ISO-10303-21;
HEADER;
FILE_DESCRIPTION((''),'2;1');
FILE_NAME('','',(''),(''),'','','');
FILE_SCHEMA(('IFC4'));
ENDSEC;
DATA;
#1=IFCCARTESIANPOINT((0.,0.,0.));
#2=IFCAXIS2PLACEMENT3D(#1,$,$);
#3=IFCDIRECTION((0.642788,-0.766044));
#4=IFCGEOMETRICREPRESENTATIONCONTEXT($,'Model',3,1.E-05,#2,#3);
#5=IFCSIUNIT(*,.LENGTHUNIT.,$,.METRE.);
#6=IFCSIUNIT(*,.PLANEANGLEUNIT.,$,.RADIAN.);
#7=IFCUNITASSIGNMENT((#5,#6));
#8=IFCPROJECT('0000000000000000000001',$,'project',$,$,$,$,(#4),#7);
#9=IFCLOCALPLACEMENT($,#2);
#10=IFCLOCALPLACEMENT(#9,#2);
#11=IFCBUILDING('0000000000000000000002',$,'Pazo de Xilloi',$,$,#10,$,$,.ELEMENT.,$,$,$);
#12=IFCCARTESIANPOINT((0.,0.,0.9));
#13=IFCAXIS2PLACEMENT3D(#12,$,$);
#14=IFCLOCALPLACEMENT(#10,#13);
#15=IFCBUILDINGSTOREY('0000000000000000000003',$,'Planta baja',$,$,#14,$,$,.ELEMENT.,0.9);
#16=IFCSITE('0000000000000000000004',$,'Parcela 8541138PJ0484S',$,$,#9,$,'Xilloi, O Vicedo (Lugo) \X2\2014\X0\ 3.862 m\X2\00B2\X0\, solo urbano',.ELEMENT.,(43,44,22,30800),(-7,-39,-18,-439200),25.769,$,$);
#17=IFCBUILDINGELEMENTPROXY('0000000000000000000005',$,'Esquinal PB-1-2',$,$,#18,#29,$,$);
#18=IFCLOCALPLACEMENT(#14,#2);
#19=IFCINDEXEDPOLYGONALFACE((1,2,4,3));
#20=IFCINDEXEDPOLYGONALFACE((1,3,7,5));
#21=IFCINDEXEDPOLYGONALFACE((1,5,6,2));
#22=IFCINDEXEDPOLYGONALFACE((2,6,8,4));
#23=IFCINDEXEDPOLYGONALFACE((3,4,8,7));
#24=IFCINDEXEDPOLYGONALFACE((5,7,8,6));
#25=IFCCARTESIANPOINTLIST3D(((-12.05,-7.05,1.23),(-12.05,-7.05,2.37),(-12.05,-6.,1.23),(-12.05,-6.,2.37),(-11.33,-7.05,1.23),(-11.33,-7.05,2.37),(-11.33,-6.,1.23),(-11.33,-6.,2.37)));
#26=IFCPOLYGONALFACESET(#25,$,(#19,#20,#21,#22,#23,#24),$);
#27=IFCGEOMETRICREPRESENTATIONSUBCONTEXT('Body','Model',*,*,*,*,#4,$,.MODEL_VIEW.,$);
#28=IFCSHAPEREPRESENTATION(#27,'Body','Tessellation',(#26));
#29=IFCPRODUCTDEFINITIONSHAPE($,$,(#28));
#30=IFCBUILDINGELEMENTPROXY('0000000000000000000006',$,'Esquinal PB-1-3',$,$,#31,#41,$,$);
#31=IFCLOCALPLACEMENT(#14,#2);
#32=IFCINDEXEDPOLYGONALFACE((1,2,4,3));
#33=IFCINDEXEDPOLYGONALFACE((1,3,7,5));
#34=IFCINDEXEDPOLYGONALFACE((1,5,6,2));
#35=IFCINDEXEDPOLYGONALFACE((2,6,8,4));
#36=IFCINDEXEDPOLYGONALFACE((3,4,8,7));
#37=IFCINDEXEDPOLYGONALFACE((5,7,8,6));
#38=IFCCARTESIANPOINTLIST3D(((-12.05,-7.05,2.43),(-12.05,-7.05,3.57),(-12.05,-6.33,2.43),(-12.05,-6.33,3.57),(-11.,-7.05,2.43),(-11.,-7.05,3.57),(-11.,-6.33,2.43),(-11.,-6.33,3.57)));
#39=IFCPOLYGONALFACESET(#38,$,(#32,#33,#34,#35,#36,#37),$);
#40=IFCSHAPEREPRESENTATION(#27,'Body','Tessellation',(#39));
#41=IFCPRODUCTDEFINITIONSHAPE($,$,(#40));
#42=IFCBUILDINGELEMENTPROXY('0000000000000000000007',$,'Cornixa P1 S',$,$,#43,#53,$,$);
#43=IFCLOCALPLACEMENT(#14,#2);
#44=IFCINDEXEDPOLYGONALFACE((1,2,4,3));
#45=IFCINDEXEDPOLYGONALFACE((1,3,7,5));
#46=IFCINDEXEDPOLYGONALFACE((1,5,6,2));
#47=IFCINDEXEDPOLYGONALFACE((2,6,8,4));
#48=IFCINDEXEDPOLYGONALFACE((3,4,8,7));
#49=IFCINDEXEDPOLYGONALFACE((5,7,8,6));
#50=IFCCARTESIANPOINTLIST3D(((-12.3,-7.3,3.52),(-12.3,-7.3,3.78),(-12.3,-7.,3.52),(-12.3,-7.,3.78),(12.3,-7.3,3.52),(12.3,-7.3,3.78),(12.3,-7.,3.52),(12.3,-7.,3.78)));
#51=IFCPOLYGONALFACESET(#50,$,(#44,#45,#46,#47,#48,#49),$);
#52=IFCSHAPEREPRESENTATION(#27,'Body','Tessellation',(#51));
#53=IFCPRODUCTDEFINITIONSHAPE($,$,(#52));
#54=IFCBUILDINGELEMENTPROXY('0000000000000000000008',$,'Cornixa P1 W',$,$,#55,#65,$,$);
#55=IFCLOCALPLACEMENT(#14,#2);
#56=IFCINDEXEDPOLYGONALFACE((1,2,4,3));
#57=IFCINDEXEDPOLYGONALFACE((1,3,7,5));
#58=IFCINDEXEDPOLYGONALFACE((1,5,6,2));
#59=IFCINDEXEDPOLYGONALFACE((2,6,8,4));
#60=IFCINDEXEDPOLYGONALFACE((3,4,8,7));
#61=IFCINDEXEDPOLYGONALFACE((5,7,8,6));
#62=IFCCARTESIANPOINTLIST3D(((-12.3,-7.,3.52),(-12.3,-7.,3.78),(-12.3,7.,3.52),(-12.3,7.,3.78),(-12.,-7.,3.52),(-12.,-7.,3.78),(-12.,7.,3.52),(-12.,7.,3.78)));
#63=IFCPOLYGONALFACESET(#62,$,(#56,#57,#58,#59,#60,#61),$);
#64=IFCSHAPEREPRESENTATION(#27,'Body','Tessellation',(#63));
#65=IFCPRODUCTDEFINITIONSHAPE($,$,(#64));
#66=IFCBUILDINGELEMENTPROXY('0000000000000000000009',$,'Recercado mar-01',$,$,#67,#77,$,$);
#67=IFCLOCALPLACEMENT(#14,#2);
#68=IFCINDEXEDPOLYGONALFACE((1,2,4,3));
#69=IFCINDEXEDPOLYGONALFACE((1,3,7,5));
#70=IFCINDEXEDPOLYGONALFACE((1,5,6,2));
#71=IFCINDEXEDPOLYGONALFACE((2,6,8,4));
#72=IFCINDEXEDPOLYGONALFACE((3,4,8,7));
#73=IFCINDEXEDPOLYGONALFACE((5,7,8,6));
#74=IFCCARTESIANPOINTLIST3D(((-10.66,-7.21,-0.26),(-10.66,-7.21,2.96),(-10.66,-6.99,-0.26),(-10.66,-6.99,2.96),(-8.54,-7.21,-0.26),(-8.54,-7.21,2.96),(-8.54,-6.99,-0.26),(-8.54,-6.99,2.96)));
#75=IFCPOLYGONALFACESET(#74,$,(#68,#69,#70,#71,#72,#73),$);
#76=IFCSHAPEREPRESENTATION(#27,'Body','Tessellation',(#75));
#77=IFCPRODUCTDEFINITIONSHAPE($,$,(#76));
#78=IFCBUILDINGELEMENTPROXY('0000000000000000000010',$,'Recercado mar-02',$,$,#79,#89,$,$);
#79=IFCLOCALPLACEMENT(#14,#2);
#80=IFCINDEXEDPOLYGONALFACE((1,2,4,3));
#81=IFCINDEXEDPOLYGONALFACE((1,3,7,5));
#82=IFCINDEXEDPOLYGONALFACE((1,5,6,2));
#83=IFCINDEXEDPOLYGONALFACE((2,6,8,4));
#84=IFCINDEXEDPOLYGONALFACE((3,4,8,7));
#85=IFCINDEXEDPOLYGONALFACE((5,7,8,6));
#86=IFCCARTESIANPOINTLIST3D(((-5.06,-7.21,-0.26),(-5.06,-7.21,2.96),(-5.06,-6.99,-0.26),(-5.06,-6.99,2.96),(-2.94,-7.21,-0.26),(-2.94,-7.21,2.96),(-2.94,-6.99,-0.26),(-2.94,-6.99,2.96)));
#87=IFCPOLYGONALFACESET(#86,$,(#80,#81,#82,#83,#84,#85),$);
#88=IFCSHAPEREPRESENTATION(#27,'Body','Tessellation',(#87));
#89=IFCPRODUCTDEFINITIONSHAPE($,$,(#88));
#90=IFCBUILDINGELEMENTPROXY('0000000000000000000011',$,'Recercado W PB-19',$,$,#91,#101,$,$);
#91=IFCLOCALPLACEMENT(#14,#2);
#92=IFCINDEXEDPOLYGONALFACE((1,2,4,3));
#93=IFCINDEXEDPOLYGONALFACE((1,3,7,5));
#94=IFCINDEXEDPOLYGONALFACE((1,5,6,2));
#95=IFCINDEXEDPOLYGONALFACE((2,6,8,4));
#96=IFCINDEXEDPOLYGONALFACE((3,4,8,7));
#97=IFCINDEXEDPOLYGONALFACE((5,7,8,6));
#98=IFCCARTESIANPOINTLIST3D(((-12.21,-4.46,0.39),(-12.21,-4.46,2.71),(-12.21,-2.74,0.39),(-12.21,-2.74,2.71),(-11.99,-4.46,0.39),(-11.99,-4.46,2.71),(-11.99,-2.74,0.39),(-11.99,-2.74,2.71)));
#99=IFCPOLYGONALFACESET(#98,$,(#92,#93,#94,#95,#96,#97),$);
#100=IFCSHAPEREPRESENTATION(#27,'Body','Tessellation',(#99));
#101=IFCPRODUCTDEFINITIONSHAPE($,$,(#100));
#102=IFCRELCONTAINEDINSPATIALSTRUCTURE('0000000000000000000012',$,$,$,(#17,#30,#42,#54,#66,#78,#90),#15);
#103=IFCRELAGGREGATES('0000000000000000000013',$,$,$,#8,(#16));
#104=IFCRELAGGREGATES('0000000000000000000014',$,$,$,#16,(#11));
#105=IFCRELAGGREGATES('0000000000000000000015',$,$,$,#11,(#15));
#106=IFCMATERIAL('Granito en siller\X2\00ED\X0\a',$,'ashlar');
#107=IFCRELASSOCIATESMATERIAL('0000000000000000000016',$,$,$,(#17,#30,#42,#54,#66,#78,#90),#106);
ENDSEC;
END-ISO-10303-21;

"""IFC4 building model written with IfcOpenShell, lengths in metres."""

from ifc_helpers import new_model, si_unit, direction, frame, origin, origin_2d, place, context, subcontext, project, spatial, rectangle, extrude, material, element, save


model = new_model("IFC4")

# Units and contexts
model_context = context("Model", 3, precision=1e-05, world=origin(), true_north=direction((0.642788, -0.766044)))
body_context = subcontext(model_context, "Body", "Model", "MODEL_VIEW")
ifc_project = project(units=[si_unit("LENGTHUNIT", "METRE"), si_unit("PLANEANGLEUNIT", "RADIAN")], contexts=[model_context])

# Site, building, storey
site_placement = place(None, origin())
site = spatial("IfcSite", under=ifc_project, at=site_placement, Name="Parcela 8541138PJ0484S", LongName="Xilloi, O Vicedo (Lugo) — 3.862 m², solo urbano", CompositionType="ELEMENT", RefLatitude=(43, 44, 22, 30800), RefLongitude=(-7, -39, -18, -439200), RefElevation=25.769)
building_placement = place(site_placement, origin())
building = spatial("IfcBuilding", under=site, at=building_placement, Name="Pazo de Xilloi", CompositionType="ELEMENT")
storey_placement = place(building_placement, frame((0.0, 0.0, 0.9)))
storey = spatial("IfcBuildingStorey", under=building, at=storey_placement, Name="Planta baja", CompositionType="ELEMENT", Elevation=0.9)

# Building element proxies
ifc_material_1 = material(Name="Granito en sillería", Category="ashlar")
proxy_1_placement = place(storey_placement, frame((-11.69, -6.525, 1.8)))
element("IfcBuildingElementProxy", 1, at=proxy_1_placement, inside=storey, material=ifc_material_1, Name="Esquinal PB-1-2", context=body_context, shape_type="SweptSolid", body=[
    extrude(rectangle(XDim=0.72, YDim=1.05, at=origin_2d()), frame((0.0, 0.0, -0.57)), (0.0, 0.0, 1.0), 1.14),
])
proxy_2_placement = place(storey_placement, frame((-11.525, -6.69, 3.0)))
element("IfcBuildingElementProxy", 2, at=proxy_2_placement, inside=storey, material=ifc_material_1, Name="Esquinal PB-1-3", context=body_context, shape_type="SweptSolid", body=[
    extrude(rectangle(XDim=1.05, YDim=0.72, at=origin_2d()), frame((0.0, 0.0, -0.57)), (0.0, 0.0, 1.0), 1.14),
])
proxy_3_placement = place(storey_placement, frame((0.0, -7.15, 3.65)))
element("IfcBuildingElementProxy", 3, at=proxy_3_placement, inside=storey, material=ifc_material_1, Name="Cornixa P1 S", context=body_context, shape_type="SweptSolid", body=[
    extrude(rectangle(XDim=24.6, YDim=0.3, at=origin_2d()), frame((0.0, 0.0, -0.13)), (0.0, 0.0, 1.0), 0.26),
])
proxy_4_placement = place(storey_placement, frame((-12.15, 0.0, 3.65)))
element("IfcBuildingElementProxy", 4, at=proxy_4_placement, inside=storey, material=ifc_material_1, Name="Cornixa P1 W", context=body_context, shape_type="SweptSolid", body=[
    extrude(rectangle(XDim=0.3, YDim=14.0, at=origin_2d()), frame((0.0, 0.0, -0.13)), (0.0, 0.0, 1.0), 0.26),
])
for number, where, name in (
    (5, (-9.6, -7.1, 1.35), "Recercado mar-01"),
    (6, (-4.0, -7.1, 1.35), "Recercado mar-02"),
):
    element("IfcBuildingElementProxy", number, at=place(storey_placement, frame(where)), inside=storey, material=ifc_material_1, Name=name, context=body_context, shape_type="SweptSolid", body=[
        extrude(rectangle(XDim=2.12, YDim=0.22, at=origin_2d()), frame((0.0, 0.0, -1.61)), (0.0, 0.0, 1.0), 3.22),
    ])
proxy_5_placement = place(storey_placement, frame((-12.1, -3.6, 1.55)))
element("IfcBuildingElementProxy", 7, at=proxy_5_placement, inside=storey, material=ifc_material_1, Name="Recercado W PB-19", context=body_context, shape_type="SweptSolid", body=[
    extrude(rectangle(XDim=0.22, YDim=1.72, at=origin_2d()), frame((0.0, 0.0, -1.16)), (0.0, 0.0, 1.0), 2.32),
])

save(model, "model.ifc")
